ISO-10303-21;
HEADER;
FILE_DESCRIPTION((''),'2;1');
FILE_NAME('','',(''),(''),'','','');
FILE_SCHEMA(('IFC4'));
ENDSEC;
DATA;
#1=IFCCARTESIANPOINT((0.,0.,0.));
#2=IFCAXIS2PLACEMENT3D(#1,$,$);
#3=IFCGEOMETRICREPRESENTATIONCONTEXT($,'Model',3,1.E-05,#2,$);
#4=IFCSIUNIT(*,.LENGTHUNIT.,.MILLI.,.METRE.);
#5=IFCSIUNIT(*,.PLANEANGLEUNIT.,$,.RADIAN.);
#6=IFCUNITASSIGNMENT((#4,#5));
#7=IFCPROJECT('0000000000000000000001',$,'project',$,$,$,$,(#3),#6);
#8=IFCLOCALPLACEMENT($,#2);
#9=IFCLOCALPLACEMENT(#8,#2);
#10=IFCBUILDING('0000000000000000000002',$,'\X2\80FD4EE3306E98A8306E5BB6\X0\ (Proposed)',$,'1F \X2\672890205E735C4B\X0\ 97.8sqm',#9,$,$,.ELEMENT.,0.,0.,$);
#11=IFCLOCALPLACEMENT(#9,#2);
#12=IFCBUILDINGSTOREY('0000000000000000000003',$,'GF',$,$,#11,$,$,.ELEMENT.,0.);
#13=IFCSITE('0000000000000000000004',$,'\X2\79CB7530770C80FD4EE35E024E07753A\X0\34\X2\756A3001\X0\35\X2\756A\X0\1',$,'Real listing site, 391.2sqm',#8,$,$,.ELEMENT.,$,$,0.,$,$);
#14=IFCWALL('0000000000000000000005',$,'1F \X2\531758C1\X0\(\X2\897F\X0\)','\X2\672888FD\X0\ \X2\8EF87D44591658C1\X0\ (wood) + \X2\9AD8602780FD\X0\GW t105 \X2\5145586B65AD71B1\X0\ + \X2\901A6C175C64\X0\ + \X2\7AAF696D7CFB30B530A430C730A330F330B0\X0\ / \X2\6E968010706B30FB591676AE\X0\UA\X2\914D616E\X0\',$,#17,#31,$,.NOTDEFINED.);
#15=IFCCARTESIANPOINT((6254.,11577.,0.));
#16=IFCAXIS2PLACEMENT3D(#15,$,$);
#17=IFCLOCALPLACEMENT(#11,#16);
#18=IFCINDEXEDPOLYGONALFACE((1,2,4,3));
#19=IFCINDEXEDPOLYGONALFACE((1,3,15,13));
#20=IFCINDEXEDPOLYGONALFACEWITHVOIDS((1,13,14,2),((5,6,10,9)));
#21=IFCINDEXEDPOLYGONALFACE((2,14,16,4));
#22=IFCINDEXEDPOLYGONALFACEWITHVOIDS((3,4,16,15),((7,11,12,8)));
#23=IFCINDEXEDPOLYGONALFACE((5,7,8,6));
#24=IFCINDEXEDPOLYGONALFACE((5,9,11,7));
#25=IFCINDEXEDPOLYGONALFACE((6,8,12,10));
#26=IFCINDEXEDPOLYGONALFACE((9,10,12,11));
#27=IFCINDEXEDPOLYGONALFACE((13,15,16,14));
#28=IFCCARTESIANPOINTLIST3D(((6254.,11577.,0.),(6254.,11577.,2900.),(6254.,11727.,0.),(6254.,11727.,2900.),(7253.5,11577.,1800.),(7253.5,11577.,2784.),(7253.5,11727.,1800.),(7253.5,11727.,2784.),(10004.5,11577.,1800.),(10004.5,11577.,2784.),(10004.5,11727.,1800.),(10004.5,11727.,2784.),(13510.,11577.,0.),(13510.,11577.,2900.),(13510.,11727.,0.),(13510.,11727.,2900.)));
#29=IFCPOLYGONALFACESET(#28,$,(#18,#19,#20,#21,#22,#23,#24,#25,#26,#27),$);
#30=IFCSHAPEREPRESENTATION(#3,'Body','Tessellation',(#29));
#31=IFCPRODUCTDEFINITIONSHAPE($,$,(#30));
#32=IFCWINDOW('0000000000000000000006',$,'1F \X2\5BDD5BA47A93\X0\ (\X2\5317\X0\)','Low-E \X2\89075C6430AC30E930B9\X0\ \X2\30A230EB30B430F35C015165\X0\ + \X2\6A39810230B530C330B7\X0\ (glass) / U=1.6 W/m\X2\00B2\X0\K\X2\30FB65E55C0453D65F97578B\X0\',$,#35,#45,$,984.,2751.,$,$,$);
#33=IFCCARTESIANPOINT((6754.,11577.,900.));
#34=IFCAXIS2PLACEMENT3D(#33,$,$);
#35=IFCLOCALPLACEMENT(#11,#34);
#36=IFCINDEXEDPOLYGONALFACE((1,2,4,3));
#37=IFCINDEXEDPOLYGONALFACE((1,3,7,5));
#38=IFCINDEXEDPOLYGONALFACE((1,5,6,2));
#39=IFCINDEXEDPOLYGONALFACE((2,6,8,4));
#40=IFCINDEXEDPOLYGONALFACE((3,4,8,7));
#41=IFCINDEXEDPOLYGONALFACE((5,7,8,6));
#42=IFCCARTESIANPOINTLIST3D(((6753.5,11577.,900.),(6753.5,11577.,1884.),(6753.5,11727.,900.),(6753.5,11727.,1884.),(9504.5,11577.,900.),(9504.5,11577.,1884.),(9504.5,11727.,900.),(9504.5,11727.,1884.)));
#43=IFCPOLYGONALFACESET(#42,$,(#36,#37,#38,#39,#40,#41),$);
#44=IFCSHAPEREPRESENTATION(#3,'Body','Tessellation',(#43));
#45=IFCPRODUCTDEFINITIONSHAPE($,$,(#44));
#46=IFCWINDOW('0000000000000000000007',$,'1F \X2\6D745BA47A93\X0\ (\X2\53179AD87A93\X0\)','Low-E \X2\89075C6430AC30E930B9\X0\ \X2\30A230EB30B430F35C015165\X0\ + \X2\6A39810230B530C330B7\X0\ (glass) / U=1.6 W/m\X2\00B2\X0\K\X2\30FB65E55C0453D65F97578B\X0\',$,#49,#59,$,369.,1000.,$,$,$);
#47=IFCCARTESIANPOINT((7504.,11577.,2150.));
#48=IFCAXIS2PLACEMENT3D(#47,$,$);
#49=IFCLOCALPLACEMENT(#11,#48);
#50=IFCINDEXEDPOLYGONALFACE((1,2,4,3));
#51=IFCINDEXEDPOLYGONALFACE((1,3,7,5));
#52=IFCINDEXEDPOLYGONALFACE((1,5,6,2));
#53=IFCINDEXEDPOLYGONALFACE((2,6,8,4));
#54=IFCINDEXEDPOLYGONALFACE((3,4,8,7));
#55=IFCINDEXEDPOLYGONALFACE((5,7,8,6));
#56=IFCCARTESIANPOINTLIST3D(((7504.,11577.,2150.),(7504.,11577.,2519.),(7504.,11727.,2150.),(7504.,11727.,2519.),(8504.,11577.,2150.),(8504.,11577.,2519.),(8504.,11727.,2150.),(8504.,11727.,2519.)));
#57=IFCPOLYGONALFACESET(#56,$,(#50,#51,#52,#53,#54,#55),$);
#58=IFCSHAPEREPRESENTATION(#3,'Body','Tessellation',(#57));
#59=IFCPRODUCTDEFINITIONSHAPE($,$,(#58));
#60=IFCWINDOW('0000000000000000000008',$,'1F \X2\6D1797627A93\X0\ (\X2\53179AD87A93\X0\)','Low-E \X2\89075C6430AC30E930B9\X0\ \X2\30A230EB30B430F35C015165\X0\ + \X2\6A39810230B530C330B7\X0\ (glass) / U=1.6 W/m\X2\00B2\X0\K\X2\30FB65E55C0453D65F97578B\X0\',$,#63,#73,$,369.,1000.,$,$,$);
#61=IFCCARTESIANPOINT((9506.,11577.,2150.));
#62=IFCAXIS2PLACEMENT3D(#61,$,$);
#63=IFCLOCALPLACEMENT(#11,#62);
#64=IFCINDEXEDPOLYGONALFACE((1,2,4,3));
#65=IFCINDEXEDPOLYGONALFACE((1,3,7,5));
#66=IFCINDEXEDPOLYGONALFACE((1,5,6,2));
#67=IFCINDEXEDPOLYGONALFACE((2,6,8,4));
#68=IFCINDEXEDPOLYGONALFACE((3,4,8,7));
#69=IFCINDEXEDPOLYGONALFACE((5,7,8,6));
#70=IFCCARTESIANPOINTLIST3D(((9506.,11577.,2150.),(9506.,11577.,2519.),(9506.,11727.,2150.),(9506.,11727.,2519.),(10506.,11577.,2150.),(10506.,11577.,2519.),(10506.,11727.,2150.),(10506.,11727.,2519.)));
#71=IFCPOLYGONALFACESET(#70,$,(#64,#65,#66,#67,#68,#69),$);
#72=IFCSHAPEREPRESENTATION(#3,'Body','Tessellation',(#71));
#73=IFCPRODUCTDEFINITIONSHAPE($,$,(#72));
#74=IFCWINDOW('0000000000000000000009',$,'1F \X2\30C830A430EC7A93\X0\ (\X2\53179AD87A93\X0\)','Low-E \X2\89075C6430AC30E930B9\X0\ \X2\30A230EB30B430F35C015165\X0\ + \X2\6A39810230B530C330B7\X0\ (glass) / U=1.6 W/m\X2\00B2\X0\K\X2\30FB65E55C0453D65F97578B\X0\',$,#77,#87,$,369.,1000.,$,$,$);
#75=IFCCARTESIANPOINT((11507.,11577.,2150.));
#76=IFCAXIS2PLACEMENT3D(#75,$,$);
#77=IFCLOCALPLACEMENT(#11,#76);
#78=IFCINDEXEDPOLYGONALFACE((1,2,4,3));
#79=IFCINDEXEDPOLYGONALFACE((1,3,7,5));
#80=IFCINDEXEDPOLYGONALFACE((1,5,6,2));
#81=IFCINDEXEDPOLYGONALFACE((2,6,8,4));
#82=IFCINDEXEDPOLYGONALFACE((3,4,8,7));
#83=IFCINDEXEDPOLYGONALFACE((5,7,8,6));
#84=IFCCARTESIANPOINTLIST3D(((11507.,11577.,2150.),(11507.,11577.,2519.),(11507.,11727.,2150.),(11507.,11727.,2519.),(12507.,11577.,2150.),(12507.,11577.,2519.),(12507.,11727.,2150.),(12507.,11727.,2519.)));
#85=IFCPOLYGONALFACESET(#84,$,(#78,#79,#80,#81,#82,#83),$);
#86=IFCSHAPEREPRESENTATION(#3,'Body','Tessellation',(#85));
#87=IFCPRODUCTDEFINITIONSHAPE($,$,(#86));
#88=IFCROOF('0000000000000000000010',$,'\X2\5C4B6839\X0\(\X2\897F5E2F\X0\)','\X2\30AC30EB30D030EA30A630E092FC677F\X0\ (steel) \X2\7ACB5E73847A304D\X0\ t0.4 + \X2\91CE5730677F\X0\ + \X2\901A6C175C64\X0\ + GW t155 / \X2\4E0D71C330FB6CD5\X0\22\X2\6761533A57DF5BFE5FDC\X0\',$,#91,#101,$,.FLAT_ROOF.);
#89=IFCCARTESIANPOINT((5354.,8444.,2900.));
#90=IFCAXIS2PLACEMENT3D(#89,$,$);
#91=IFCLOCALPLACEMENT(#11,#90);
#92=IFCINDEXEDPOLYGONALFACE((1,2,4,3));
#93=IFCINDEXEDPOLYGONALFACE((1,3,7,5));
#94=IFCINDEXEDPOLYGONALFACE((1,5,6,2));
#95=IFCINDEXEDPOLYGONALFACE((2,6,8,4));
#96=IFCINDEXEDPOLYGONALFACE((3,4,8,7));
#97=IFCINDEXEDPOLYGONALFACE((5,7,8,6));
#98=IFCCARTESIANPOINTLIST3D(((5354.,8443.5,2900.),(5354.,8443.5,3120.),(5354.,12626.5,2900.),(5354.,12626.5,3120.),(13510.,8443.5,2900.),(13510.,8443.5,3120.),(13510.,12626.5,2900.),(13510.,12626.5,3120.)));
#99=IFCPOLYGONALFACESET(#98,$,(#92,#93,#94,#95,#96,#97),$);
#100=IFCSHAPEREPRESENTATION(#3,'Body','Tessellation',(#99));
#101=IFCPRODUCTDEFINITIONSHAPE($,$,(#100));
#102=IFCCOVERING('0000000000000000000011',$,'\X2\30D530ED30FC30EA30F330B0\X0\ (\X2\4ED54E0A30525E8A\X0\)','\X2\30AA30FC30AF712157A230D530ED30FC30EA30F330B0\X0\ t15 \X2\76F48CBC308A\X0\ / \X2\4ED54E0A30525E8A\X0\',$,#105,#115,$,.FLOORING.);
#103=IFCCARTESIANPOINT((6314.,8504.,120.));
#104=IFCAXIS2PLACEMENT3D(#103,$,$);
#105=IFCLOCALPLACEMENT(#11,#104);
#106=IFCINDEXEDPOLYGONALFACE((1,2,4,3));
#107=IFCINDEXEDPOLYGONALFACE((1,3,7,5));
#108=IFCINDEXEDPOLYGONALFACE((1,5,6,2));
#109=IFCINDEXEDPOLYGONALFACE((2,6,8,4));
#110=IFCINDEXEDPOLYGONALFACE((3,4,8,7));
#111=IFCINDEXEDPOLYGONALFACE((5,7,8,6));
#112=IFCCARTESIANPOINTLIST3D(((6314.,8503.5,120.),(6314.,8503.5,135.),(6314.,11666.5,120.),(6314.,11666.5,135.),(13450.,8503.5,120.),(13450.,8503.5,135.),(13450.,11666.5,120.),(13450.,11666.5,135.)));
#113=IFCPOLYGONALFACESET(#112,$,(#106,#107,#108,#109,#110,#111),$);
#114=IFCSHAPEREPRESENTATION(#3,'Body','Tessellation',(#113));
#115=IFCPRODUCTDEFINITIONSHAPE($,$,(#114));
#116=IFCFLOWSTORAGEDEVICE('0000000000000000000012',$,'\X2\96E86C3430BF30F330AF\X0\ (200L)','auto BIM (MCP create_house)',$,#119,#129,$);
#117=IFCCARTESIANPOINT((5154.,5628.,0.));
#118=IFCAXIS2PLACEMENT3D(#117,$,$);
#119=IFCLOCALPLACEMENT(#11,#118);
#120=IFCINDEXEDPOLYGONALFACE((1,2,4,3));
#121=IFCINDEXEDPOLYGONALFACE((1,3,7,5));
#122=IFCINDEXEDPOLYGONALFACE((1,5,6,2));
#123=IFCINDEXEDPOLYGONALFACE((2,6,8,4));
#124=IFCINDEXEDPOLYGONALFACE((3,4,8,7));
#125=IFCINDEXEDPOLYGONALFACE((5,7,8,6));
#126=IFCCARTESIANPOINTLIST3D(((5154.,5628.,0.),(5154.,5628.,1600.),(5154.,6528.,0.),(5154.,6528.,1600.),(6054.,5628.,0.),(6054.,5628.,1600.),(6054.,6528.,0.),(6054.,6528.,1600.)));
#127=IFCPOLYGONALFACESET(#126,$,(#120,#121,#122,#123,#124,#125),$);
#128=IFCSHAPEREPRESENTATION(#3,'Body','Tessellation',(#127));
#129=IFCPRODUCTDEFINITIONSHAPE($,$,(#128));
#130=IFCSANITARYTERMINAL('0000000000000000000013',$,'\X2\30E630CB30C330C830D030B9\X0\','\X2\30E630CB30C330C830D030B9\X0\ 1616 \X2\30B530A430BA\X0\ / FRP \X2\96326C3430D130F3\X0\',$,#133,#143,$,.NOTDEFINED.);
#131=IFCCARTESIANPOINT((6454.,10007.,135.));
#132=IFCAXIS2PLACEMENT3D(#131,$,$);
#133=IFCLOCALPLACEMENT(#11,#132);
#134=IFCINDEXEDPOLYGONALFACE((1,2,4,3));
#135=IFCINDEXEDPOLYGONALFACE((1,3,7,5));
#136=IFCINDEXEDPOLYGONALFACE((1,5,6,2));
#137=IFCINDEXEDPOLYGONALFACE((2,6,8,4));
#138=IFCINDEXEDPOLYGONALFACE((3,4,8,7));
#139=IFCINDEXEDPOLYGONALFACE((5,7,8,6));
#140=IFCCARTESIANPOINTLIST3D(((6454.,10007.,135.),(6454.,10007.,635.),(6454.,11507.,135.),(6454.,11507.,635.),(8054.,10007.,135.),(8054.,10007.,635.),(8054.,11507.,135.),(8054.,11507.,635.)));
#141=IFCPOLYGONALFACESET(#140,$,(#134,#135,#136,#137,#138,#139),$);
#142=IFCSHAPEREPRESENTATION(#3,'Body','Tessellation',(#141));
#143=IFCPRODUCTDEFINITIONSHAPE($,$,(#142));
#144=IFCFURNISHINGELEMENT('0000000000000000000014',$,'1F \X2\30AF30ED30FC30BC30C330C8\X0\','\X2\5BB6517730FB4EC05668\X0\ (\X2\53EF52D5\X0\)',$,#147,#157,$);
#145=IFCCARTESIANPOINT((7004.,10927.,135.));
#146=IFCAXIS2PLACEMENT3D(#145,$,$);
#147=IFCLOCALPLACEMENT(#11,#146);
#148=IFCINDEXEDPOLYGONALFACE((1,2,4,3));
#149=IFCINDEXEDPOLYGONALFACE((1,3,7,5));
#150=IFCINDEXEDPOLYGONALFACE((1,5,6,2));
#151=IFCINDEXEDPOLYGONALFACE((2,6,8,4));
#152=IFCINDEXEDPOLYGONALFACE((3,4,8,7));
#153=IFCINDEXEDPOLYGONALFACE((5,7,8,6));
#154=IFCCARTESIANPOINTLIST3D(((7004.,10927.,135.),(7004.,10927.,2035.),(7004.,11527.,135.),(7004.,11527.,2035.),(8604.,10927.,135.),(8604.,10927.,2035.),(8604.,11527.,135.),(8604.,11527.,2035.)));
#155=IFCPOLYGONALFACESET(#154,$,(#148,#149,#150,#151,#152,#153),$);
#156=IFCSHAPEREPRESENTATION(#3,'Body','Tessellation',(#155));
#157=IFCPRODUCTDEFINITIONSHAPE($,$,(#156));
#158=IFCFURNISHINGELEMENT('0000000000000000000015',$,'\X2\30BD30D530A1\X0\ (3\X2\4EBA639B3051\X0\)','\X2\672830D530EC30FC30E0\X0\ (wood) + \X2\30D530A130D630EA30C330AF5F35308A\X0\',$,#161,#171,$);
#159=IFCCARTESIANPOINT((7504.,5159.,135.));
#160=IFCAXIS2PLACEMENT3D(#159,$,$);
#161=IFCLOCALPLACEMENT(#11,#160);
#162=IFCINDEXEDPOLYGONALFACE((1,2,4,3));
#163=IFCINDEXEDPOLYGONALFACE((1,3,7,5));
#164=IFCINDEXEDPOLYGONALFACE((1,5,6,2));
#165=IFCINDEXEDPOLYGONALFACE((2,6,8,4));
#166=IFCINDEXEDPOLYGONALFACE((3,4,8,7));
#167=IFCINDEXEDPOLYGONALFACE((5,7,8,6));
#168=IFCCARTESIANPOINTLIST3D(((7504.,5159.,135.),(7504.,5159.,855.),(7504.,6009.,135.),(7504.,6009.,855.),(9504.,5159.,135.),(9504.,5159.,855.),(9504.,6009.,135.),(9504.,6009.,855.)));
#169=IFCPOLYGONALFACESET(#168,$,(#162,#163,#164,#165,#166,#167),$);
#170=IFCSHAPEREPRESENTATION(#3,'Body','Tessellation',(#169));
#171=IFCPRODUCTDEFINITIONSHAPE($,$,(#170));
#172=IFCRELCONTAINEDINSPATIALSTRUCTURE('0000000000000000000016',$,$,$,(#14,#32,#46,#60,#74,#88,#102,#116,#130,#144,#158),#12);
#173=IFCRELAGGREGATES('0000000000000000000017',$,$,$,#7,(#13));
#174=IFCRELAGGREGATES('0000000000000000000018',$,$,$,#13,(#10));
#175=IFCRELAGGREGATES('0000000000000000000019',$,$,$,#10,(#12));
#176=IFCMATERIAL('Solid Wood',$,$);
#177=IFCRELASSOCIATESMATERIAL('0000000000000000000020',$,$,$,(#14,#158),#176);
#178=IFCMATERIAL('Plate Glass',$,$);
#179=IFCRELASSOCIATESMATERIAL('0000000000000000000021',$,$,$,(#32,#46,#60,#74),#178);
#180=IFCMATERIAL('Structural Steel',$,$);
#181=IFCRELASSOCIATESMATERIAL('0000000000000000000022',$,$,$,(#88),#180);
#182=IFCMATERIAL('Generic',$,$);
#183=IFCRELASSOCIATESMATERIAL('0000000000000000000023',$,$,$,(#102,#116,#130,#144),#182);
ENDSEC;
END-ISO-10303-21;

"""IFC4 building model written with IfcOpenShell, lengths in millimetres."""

from ifc_helpers import new_model, si_unit, frame, frame_2d, origin, place, context, project, spatial, rectangle, extrude, material, element, fill, save


model = new_model("IFC4")

# Units and contexts
model_context = context("Model", 3, precision=1e-05, world=origin())
ifc_project = project(units=[si_unit("LENGTHUNIT", "METRE", prefix="MILLI"), si_unit("PLANEANGLEUNIT", "RADIAN")], contexts=[model_context])

# Site, building, storey
site_placement = place(None, origin())
site = spatial("IfcSite", under=ifc_project, at=site_placement, Name="秋田県能代市万町34番、35番1", ObjectType="Real listing site, 391.2sqm", CompositionType="ELEMENT", RefElevation=0.0)
building_placement = place(site_placement, origin())
building = spatial("IfcBuilding", under=site, at=building_placement, Name="能代の風の家 (Proposed)", ObjectType="1F 木造平屋 97.8sqm", CompositionType="ELEMENT", ElevationOfRefHeight=0.0, ElevationOfTerrain=0.0)
storey_placement = place(building_placement, origin())
storey = spatial("IfcBuildingStorey", under=building, at=storey_placement, Name="GF", CompositionType="ELEMENT", Elevation=0.0)

# Shared definitions
ifc_material_1 = material(Name="Solid Wood")

# Shared definitions
ifc_material_2 = material(Name="Plate Glass")

# Wall, openings, windows
wall_1_placement = place(storey_placement, frame((6254.0, 11577.0, 0.0)))
wall_1 = element("IfcWall", 1, at=wall_1_placement, inside=storey, material=ifc_material_1, Name="1F 北壁(西)", Description="木製 軸組外壁 (wood) + 高性能GW t105 充填断熱 + 通気層 + 窯業系サイディング / 準耐火・外皮UA配慮", PredefinedType="NOTDEFINED", context=model_context, shape_type="SweptSolid", body=[
    extrude(rectangle(XDim=7256.0, YDim=150.0, at=frame_2d((3628.0, 75.0))), frame((6254.0, 11577.0, 0.0)), (0.0, 0.0, 1.0), 2900.0),
])
opening_1_placement = place(storey_placement, frame((6754.0, 11577.0, 900.0)))
opening_1 = element("IfcOpeningElement", 2, at=opening_1_placement, cuts=wall_1, PredefinedType="NOTDEFINED", context=model_context, shape_type="SweptSolid", body=[
    extrude(rectangle(XDim=2751.0, YDim=150.0, at=frame_2d((1375.0, 75.0))), frame((6754.0, 11577.0, 900.0)), (0.0, 0.0, 1.0), 984.0),
])
opening_2_placement = place(storey_placement, frame((7504.0, 11577.0, 2150.0)))
opening_2 = element("IfcOpeningElement", 3, at=opening_2_placement, cuts=wall_1, PredefinedType="NOTDEFINED", context=model_context, shape_type="SweptSolid", body=[
    extrude(rectangle(XDim=1000.0, YDim=150.0, at=frame_2d((500.0, 75.0))), frame((7504.0, 11577.0, 2150.0)), (0.0, 0.0, 1.0), 369.0),
])
opening_3_placement = place(storey_placement, frame((9506.0, 11577.0, 2150.0)))
opening_3 = element("IfcOpeningElement", 4, at=opening_3_placement, cuts=wall_1, PredefinedType="NOTDEFINED", context=model_context, shape_type="SweptSolid", body=[
    extrude(rectangle(XDim=1000.0, YDim=150.0, at=frame_2d((500.0, 75.0))), frame((9506.0, 11577.0, 2150.0)), (0.0, 0.0, 1.0), 369.0),
])
opening_4_placement = place(storey_placement, frame((11507.0, 11577.0, 2150.0)))
opening_4 = element("IfcOpeningElement", 5, at=opening_4_placement, cuts=wall_1, PredefinedType="NOTDEFINED", context=model_context, shape_type="SweptSolid", body=[
    extrude(rectangle(XDim=1000.0, YDim=150.0, at=frame_2d((500.0, 75.0))), frame((11507.0, 11577.0, 2150.0)), (0.0, 0.0, 1.0), 369.0),
])
window_1_placement = place(storey_placement, frame((6754.0, 11577.0, 900.0)))
window_1 = element("IfcWindow", 6, at=window_1_placement, inside=storey, material=ifc_material_2, Name="1F 寝室窓 (北)", Description="Low-E 複層ガラス アルゴン封入 + 樹脂サッシ (glass) / U=1.6 W/m²K・日射取得型", OverallHeight=984.0, OverallWidth=2751.0, context=model_context, shape_type="SweptSolid", body=[
    extrude(rectangle(XDim=2751.0, YDim=150.0, at=frame_2d((1375.0, 75.0))), frame((6754.0, 11577.0, 900.0)), (0.0, 0.0, 1.0), 984.0),
])
fill(opening_1, window_1)
window_2_placement = place(storey_placement, frame((7504.0, 11577.0, 2150.0)))
window_2 = element("IfcWindow", 7, at=window_2_placement, inside=storey, material=ifc_material_2, Name="1F 浴室窓 (北高窓)", Description="Low-E 複層ガラス アルゴン封入 + 樹脂サッシ (glass) / U=1.6 W/m²K・日射取得型", OverallHeight=369.0, OverallWidth=1000.0, context=model_context, shape_type="SweptSolid", body=[
    extrude(rectangle(XDim=1000.0, YDim=150.0, at=frame_2d((500.0, 75.0))), frame((7504.0, 11577.0, 2150.0)), (0.0, 0.0, 1.0), 369.0),
])
fill(opening_2, window_2)
window_3_placement = place(storey_placement, frame((9506.0, 11577.0, 2150.0)))
window_3 = element("IfcWindow", 8, at=window_3_placement, inside=storey, material=ifc_material_2, Name="1F 洗面窓 (北高窓)", Description="Low-E 複層ガラス アルゴン封入 + 樹脂サッシ (glass) / U=1.6 W/m²K・日射取得型", OverallHeight=369.0, OverallWidth=1000.0, context=model_context, shape_type="SweptSolid", body=[
    extrude(rectangle(XDim=1000.0, YDim=150.0, at=frame_2d((500.0, 75.0))), frame((9506.0, 11577.0, 2150.0)), (0.0, 0.0, 1.0), 369.0),
])
fill(opening_3, window_3)
window_4_placement = place(storey_placement, frame((11507.0, 11577.0, 2150.0)))
window_4 = element("IfcWindow", 9, at=window_4_placement, inside=storey, material=ifc_material_2, Name="1F トイレ窓 (北高窓)", Description="Low-E 複層ガラス アルゴン封入 + 樹脂サッシ (glass) / U=1.6 W/m²K・日射取得型", OverallHeight=369.0, OverallWidth=1000.0, context=model_context, shape_type="SweptSolid", body=[
    extrude(rectangle(XDim=1000.0, YDim=150.0, at=frame_2d((500.0, 75.0))), frame((11507.0, 11577.0, 2150.0)), (0.0, 0.0, 1.0), 369.0),
])
fill(opening_4, window_4)

# Roof
ifc_material_3 = material(Name="Structural Steel")
roof_1_placement = place(storey_placement, frame((5354.0, 8444.0, 2900.0)))
element("IfcRoof", 10, at=roof_1_placement, inside=storey, material=ifc_material_3, Name="屋根(西帯)", Description="ガルバリウム鋼板 (steel) 立平葺き t0.4 + 野地板 + 通気層 + GW t155 / 不燃・法22条区域対応", PredefinedType="FLAT_ROOF", context=model_context, shape_type="SweptSolid", body=[
    extrude(rectangle(XDim=8156.0, YDim=4183.0, at=frame_2d((4078.0, 2091.0))), frame((5354.0, 8444.0, 2900.0)), (0.0, 0.0, 1.0), 220.0),
])

# Covering
ifc_material_4 = material(Name="Generic")
covering_1_placement = place(storey_placement, frame((6314.0, 8504.0, 120.0)))
element("IfcCovering", 11, at=covering_1_placement, inside=storey, material=ifc_material_4, Name="フローリング (仕上げ床)", Description="オーク無垢フローリング t15 直貼り / 仕上げ床", PredefinedType="FLOORING", context=model_context, shape_type="SweptSolid", body=[
    extrude(rectangle(XDim=7136.0, YDim=3163.0, at=frame_2d((3568.0, 1581.0))), frame((6314.0, 8504.0, 120.0)), (0.0, 0.0, 1.0), 15.0),
])

# Flow storage device
flow_storage_device_placement = place(storey_placement, frame((5154.0, 5628.0, 0.0)))
element("IfcFlowStorageDevice", 12, at=flow_storage_device_placement, inside=storey, material=ifc_material_4, Name="雨水タンク (200L)", Description="auto BIM (MCP create_house)", context=model_context, shape_type="SweptSolid", body=[
    extrude(rectangle(XDim=900.0, YDim=900.0, at=frame_2d((450.0, 450.0))), frame((5154.0, 5628.0, 0.0)), (0.0, 0.0, 1.0), 1600.0),
])

# Sanitary terminal
sanitary_terminal_placement = place(storey_placement, frame((6454.0, 10007.0, 135.0)))
element("IfcSanitaryTerminal", 13, at=sanitary_terminal_placement, inside=storey, material=ifc_material_4, Name="ユニットバス", Description="ユニットバス 1616 サイズ / FRP 防水パン", PredefinedType="NOTDEFINED", context=model_context, shape_type="SweptSolid", body=[
    extrude(rectangle(XDim=1600.0, YDim=1500.0, at=frame_2d((800.0, 750.0))), frame((6454.0, 10007.0, 135.0)), (0.0, 0.0, 1.0), 500.0),
])

# Furnishing elements
furnishing_1_placement = place(storey_placement, frame((7004.0, 10927.0, 135.0)))
element("IfcFurnishingElement", 14, at=furnishing_1_placement, inside=storey, material=ifc_material_4, Name="1F クローゼット", Description="家具・什器 (可動)", context=model_context, shape_type="SweptSolid", body=[
    extrude(rectangle(XDim=1600.0, YDim=600.0, at=frame_2d((800.0, 300.0))), frame((7004.0, 10927.0, 135.0)), (0.0, 0.0, 1.0), 1900.0),
])
furnishing_2_placement = place(storey_placement, frame((7504.0, 5159.0, 135.0)))
element("IfcFurnishingElement", 15, at=furnishing_2_placement, inside=storey, material=ifc_material_1, Name="ソファ (3人掛け)", Description="木フレーム (wood) + ファブリック張り", context=model_context, shape_type="SweptSolid", body=[
    extrude(rectangle(XDim=2000.0, YDim=850.0, at=frame_2d((1000.0, 425.0))), frame((7504.0, 5159.0, 135.0)), (0.0, 0.0, 1.0), 720.0),
])

save(model, "model.ifc")
